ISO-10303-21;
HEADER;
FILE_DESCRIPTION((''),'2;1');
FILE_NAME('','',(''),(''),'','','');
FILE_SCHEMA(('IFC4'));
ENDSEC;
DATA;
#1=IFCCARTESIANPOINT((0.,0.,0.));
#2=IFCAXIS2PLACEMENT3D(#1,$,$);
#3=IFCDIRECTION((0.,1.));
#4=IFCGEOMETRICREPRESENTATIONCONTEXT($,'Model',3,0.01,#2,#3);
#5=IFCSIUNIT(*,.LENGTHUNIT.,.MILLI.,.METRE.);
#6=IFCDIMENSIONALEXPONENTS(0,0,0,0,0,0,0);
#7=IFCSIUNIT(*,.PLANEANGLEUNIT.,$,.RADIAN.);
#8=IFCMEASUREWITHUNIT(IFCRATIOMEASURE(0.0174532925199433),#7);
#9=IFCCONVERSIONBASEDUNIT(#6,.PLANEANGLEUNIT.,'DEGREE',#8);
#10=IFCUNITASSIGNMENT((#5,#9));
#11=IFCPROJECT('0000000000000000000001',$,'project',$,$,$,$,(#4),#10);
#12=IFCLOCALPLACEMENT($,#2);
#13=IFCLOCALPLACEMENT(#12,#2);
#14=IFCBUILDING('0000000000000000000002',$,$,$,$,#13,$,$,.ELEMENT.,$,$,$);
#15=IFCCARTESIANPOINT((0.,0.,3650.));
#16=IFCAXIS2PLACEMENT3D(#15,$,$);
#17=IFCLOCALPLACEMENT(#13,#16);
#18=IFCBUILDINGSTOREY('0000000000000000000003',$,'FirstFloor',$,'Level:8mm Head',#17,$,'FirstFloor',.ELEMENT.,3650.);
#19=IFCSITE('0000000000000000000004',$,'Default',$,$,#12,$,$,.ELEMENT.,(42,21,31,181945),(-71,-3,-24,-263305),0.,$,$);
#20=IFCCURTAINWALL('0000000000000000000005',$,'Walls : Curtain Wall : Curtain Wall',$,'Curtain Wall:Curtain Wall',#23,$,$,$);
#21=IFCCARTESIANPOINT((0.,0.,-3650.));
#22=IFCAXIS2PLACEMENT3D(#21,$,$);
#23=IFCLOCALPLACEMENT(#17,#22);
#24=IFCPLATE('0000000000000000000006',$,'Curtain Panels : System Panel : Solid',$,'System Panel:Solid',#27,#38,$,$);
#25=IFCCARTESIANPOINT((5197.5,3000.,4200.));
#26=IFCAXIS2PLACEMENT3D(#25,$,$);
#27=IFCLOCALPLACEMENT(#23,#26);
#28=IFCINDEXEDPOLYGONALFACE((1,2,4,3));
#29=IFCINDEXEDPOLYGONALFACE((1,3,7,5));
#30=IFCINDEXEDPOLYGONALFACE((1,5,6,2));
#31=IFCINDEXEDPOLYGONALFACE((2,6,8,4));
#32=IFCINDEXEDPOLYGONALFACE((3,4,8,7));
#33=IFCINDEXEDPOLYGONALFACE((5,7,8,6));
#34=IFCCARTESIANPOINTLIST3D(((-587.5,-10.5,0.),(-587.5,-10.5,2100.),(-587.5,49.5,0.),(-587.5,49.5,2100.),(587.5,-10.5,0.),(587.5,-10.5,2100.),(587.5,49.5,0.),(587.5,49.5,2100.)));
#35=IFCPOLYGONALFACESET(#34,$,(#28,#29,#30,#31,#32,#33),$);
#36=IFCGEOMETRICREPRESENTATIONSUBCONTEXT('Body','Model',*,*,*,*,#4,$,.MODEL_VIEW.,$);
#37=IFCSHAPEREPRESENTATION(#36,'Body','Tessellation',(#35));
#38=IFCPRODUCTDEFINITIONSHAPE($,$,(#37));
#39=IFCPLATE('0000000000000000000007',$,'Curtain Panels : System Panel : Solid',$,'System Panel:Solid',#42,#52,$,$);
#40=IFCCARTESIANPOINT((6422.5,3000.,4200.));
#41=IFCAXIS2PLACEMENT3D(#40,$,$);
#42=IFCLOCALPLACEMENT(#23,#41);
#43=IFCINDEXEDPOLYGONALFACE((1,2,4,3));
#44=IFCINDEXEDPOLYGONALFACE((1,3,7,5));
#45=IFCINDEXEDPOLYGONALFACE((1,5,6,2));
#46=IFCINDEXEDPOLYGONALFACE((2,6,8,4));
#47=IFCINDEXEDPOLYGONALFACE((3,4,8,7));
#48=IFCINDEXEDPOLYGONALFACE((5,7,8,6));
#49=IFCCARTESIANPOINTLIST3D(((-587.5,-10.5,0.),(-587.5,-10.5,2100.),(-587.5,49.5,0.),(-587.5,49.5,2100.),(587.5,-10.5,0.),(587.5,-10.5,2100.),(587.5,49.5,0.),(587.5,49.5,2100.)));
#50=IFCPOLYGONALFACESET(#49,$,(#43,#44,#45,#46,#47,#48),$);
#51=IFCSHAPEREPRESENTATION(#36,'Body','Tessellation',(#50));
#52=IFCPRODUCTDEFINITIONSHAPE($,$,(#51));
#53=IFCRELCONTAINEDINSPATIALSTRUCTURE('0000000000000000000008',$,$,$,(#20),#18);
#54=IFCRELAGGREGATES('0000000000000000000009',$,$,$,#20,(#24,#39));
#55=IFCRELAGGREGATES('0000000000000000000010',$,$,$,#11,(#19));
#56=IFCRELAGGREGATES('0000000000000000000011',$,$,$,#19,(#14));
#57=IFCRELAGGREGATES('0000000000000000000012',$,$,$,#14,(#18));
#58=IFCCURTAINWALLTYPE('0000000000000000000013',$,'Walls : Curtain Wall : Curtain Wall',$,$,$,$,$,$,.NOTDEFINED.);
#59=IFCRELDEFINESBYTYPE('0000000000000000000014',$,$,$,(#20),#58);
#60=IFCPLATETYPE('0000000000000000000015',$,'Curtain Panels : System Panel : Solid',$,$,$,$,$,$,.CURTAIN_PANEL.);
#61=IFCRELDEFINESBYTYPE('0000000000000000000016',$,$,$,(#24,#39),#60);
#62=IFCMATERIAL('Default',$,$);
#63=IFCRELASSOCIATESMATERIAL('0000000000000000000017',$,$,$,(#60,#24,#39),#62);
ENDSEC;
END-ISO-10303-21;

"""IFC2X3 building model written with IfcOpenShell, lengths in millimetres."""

from ifc_helpers import new_model, entity, si_unit, converted_unit, direction, frame, origin, origin_2d_with_axis, place, context, subcontext, project, spatial, rectangle, extrude, source, transform, mapped, material, type_object, type_shapes, element, aggregate, save


model = new_model("IFC2X3")

# Units and contexts
model_context = context("Model", 3, precision=0.01, world=origin(), true_north=direction((0.0, 1.0)))
body_context = subcontext(model_context, "Body", "Model", "MODEL_VIEW")
ifc_project = project(units=[si_unit("LENGTHUNIT", "METRE", prefix="MILLI"), converted_unit("PLANEANGLEUNIT", "DEGREE", entity("IfcRatioMeasure", 0.0174532925199433), si_unit("PLANEANGLEUNIT", "RADIAN"), dimensions=[0, 0, 0, 0, 0, 0, 0])], contexts=[model_context])

# Site, building, storey
site_placement = place(None, origin())
site = spatial("IfcSite", under=ifc_project, at=site_placement, Name="Default", CompositionType="ELEMENT", RefLatitude=(42, 21, 31, 181945), RefLongitude=(-71, -3, -24, -263305), RefElevation=0.0)
building_placement = place(site_placement, origin())
building = spatial("IfcBuilding", under=site, at=building_placement, CompositionType="ELEMENT")
storey_placement = place(building_placement, frame((0.0, 0.0, 3650.0)))
storey = spatial("IfcBuildingStorey", under=building, at=storey_placement, Name="FirstFloor", ObjectType="Level:8mm Head", LongName="FirstFloor", CompositionType="ELEMENT", Elevation=3650.0)

# Curtain wall, plates
curtain_wall_type = type_object("IfcCurtainWallType", Name="Walls : Curtain Wall : Curtain Wall", PredefinedType="NOTDEFINED")
curtain_wall_placement = place(storey_placement, frame((0.0, 0.0, -3650.0)))
curtain_wall = element("IfcCurtainWall", 1, at=curtain_wall_placement, inside=storey, type_object=curtain_wall_type, Name="Walls : Curtain Wall : Curtain Wall", ObjectType="Curtain Wall:Curtain Wall")
ifc_material_1 = material(Name="Default")
plate_type = type_object("IfcPlateType", Name="Curtain Panels : System Panel : Solid", PredefinedType="CURTAIN_PANEL", material=ifc_material_1)
shared_shape_1 = source(origin(), body_context, "Body", "SweptSolid", [
    extrude(rectangle(XDim=60.0, YDim=1175.0, at=origin_2d_with_axis()), frame((0.0, 19.5, 0.0), z_axis=(0.0, 0.0, 1.0), x_axis=(0.0, 1.0, 0.0)), (0.0, 0.0, 1.0), 2100.0),
])
type_shapes(plate_type, [shared_shape_1])
plate_1_placement = place(curtain_wall_placement, frame((5197.5, 3000.0, 4200.0)))
plate_1 = element("IfcPlate", 2, at=plate_1_placement, type_object=plate_type, material=ifc_material_1, Name="Curtain Panels : System Panel : Solid", ObjectType="System Panel:Solid", context=body_context, shape_type="MappedRepresentation", body=[
    mapped(shared_shape_1, transform((0.0, 0.0, 0.0), scale=1.0)),
])
plate_2_placement = place(curtain_wall_placement, frame((6422.5, 3000.0, 4200.0)))
plate_2 = element("IfcPlate", 3, at=plate_2_placement, type_object=plate_type, material=ifc_material_1, Name="Curtain Panels : System Panel : Solid", ObjectType="System Panel:Solid", context=body_context, shape_type="MappedRepresentation", body=[
    mapped(shared_shape_1, transform((0.0, 0.0, 0.0), scale=1.0)),
])
aggregate(curtain_wall, [plate_1, plate_2])

save(model, "model.ifc")
